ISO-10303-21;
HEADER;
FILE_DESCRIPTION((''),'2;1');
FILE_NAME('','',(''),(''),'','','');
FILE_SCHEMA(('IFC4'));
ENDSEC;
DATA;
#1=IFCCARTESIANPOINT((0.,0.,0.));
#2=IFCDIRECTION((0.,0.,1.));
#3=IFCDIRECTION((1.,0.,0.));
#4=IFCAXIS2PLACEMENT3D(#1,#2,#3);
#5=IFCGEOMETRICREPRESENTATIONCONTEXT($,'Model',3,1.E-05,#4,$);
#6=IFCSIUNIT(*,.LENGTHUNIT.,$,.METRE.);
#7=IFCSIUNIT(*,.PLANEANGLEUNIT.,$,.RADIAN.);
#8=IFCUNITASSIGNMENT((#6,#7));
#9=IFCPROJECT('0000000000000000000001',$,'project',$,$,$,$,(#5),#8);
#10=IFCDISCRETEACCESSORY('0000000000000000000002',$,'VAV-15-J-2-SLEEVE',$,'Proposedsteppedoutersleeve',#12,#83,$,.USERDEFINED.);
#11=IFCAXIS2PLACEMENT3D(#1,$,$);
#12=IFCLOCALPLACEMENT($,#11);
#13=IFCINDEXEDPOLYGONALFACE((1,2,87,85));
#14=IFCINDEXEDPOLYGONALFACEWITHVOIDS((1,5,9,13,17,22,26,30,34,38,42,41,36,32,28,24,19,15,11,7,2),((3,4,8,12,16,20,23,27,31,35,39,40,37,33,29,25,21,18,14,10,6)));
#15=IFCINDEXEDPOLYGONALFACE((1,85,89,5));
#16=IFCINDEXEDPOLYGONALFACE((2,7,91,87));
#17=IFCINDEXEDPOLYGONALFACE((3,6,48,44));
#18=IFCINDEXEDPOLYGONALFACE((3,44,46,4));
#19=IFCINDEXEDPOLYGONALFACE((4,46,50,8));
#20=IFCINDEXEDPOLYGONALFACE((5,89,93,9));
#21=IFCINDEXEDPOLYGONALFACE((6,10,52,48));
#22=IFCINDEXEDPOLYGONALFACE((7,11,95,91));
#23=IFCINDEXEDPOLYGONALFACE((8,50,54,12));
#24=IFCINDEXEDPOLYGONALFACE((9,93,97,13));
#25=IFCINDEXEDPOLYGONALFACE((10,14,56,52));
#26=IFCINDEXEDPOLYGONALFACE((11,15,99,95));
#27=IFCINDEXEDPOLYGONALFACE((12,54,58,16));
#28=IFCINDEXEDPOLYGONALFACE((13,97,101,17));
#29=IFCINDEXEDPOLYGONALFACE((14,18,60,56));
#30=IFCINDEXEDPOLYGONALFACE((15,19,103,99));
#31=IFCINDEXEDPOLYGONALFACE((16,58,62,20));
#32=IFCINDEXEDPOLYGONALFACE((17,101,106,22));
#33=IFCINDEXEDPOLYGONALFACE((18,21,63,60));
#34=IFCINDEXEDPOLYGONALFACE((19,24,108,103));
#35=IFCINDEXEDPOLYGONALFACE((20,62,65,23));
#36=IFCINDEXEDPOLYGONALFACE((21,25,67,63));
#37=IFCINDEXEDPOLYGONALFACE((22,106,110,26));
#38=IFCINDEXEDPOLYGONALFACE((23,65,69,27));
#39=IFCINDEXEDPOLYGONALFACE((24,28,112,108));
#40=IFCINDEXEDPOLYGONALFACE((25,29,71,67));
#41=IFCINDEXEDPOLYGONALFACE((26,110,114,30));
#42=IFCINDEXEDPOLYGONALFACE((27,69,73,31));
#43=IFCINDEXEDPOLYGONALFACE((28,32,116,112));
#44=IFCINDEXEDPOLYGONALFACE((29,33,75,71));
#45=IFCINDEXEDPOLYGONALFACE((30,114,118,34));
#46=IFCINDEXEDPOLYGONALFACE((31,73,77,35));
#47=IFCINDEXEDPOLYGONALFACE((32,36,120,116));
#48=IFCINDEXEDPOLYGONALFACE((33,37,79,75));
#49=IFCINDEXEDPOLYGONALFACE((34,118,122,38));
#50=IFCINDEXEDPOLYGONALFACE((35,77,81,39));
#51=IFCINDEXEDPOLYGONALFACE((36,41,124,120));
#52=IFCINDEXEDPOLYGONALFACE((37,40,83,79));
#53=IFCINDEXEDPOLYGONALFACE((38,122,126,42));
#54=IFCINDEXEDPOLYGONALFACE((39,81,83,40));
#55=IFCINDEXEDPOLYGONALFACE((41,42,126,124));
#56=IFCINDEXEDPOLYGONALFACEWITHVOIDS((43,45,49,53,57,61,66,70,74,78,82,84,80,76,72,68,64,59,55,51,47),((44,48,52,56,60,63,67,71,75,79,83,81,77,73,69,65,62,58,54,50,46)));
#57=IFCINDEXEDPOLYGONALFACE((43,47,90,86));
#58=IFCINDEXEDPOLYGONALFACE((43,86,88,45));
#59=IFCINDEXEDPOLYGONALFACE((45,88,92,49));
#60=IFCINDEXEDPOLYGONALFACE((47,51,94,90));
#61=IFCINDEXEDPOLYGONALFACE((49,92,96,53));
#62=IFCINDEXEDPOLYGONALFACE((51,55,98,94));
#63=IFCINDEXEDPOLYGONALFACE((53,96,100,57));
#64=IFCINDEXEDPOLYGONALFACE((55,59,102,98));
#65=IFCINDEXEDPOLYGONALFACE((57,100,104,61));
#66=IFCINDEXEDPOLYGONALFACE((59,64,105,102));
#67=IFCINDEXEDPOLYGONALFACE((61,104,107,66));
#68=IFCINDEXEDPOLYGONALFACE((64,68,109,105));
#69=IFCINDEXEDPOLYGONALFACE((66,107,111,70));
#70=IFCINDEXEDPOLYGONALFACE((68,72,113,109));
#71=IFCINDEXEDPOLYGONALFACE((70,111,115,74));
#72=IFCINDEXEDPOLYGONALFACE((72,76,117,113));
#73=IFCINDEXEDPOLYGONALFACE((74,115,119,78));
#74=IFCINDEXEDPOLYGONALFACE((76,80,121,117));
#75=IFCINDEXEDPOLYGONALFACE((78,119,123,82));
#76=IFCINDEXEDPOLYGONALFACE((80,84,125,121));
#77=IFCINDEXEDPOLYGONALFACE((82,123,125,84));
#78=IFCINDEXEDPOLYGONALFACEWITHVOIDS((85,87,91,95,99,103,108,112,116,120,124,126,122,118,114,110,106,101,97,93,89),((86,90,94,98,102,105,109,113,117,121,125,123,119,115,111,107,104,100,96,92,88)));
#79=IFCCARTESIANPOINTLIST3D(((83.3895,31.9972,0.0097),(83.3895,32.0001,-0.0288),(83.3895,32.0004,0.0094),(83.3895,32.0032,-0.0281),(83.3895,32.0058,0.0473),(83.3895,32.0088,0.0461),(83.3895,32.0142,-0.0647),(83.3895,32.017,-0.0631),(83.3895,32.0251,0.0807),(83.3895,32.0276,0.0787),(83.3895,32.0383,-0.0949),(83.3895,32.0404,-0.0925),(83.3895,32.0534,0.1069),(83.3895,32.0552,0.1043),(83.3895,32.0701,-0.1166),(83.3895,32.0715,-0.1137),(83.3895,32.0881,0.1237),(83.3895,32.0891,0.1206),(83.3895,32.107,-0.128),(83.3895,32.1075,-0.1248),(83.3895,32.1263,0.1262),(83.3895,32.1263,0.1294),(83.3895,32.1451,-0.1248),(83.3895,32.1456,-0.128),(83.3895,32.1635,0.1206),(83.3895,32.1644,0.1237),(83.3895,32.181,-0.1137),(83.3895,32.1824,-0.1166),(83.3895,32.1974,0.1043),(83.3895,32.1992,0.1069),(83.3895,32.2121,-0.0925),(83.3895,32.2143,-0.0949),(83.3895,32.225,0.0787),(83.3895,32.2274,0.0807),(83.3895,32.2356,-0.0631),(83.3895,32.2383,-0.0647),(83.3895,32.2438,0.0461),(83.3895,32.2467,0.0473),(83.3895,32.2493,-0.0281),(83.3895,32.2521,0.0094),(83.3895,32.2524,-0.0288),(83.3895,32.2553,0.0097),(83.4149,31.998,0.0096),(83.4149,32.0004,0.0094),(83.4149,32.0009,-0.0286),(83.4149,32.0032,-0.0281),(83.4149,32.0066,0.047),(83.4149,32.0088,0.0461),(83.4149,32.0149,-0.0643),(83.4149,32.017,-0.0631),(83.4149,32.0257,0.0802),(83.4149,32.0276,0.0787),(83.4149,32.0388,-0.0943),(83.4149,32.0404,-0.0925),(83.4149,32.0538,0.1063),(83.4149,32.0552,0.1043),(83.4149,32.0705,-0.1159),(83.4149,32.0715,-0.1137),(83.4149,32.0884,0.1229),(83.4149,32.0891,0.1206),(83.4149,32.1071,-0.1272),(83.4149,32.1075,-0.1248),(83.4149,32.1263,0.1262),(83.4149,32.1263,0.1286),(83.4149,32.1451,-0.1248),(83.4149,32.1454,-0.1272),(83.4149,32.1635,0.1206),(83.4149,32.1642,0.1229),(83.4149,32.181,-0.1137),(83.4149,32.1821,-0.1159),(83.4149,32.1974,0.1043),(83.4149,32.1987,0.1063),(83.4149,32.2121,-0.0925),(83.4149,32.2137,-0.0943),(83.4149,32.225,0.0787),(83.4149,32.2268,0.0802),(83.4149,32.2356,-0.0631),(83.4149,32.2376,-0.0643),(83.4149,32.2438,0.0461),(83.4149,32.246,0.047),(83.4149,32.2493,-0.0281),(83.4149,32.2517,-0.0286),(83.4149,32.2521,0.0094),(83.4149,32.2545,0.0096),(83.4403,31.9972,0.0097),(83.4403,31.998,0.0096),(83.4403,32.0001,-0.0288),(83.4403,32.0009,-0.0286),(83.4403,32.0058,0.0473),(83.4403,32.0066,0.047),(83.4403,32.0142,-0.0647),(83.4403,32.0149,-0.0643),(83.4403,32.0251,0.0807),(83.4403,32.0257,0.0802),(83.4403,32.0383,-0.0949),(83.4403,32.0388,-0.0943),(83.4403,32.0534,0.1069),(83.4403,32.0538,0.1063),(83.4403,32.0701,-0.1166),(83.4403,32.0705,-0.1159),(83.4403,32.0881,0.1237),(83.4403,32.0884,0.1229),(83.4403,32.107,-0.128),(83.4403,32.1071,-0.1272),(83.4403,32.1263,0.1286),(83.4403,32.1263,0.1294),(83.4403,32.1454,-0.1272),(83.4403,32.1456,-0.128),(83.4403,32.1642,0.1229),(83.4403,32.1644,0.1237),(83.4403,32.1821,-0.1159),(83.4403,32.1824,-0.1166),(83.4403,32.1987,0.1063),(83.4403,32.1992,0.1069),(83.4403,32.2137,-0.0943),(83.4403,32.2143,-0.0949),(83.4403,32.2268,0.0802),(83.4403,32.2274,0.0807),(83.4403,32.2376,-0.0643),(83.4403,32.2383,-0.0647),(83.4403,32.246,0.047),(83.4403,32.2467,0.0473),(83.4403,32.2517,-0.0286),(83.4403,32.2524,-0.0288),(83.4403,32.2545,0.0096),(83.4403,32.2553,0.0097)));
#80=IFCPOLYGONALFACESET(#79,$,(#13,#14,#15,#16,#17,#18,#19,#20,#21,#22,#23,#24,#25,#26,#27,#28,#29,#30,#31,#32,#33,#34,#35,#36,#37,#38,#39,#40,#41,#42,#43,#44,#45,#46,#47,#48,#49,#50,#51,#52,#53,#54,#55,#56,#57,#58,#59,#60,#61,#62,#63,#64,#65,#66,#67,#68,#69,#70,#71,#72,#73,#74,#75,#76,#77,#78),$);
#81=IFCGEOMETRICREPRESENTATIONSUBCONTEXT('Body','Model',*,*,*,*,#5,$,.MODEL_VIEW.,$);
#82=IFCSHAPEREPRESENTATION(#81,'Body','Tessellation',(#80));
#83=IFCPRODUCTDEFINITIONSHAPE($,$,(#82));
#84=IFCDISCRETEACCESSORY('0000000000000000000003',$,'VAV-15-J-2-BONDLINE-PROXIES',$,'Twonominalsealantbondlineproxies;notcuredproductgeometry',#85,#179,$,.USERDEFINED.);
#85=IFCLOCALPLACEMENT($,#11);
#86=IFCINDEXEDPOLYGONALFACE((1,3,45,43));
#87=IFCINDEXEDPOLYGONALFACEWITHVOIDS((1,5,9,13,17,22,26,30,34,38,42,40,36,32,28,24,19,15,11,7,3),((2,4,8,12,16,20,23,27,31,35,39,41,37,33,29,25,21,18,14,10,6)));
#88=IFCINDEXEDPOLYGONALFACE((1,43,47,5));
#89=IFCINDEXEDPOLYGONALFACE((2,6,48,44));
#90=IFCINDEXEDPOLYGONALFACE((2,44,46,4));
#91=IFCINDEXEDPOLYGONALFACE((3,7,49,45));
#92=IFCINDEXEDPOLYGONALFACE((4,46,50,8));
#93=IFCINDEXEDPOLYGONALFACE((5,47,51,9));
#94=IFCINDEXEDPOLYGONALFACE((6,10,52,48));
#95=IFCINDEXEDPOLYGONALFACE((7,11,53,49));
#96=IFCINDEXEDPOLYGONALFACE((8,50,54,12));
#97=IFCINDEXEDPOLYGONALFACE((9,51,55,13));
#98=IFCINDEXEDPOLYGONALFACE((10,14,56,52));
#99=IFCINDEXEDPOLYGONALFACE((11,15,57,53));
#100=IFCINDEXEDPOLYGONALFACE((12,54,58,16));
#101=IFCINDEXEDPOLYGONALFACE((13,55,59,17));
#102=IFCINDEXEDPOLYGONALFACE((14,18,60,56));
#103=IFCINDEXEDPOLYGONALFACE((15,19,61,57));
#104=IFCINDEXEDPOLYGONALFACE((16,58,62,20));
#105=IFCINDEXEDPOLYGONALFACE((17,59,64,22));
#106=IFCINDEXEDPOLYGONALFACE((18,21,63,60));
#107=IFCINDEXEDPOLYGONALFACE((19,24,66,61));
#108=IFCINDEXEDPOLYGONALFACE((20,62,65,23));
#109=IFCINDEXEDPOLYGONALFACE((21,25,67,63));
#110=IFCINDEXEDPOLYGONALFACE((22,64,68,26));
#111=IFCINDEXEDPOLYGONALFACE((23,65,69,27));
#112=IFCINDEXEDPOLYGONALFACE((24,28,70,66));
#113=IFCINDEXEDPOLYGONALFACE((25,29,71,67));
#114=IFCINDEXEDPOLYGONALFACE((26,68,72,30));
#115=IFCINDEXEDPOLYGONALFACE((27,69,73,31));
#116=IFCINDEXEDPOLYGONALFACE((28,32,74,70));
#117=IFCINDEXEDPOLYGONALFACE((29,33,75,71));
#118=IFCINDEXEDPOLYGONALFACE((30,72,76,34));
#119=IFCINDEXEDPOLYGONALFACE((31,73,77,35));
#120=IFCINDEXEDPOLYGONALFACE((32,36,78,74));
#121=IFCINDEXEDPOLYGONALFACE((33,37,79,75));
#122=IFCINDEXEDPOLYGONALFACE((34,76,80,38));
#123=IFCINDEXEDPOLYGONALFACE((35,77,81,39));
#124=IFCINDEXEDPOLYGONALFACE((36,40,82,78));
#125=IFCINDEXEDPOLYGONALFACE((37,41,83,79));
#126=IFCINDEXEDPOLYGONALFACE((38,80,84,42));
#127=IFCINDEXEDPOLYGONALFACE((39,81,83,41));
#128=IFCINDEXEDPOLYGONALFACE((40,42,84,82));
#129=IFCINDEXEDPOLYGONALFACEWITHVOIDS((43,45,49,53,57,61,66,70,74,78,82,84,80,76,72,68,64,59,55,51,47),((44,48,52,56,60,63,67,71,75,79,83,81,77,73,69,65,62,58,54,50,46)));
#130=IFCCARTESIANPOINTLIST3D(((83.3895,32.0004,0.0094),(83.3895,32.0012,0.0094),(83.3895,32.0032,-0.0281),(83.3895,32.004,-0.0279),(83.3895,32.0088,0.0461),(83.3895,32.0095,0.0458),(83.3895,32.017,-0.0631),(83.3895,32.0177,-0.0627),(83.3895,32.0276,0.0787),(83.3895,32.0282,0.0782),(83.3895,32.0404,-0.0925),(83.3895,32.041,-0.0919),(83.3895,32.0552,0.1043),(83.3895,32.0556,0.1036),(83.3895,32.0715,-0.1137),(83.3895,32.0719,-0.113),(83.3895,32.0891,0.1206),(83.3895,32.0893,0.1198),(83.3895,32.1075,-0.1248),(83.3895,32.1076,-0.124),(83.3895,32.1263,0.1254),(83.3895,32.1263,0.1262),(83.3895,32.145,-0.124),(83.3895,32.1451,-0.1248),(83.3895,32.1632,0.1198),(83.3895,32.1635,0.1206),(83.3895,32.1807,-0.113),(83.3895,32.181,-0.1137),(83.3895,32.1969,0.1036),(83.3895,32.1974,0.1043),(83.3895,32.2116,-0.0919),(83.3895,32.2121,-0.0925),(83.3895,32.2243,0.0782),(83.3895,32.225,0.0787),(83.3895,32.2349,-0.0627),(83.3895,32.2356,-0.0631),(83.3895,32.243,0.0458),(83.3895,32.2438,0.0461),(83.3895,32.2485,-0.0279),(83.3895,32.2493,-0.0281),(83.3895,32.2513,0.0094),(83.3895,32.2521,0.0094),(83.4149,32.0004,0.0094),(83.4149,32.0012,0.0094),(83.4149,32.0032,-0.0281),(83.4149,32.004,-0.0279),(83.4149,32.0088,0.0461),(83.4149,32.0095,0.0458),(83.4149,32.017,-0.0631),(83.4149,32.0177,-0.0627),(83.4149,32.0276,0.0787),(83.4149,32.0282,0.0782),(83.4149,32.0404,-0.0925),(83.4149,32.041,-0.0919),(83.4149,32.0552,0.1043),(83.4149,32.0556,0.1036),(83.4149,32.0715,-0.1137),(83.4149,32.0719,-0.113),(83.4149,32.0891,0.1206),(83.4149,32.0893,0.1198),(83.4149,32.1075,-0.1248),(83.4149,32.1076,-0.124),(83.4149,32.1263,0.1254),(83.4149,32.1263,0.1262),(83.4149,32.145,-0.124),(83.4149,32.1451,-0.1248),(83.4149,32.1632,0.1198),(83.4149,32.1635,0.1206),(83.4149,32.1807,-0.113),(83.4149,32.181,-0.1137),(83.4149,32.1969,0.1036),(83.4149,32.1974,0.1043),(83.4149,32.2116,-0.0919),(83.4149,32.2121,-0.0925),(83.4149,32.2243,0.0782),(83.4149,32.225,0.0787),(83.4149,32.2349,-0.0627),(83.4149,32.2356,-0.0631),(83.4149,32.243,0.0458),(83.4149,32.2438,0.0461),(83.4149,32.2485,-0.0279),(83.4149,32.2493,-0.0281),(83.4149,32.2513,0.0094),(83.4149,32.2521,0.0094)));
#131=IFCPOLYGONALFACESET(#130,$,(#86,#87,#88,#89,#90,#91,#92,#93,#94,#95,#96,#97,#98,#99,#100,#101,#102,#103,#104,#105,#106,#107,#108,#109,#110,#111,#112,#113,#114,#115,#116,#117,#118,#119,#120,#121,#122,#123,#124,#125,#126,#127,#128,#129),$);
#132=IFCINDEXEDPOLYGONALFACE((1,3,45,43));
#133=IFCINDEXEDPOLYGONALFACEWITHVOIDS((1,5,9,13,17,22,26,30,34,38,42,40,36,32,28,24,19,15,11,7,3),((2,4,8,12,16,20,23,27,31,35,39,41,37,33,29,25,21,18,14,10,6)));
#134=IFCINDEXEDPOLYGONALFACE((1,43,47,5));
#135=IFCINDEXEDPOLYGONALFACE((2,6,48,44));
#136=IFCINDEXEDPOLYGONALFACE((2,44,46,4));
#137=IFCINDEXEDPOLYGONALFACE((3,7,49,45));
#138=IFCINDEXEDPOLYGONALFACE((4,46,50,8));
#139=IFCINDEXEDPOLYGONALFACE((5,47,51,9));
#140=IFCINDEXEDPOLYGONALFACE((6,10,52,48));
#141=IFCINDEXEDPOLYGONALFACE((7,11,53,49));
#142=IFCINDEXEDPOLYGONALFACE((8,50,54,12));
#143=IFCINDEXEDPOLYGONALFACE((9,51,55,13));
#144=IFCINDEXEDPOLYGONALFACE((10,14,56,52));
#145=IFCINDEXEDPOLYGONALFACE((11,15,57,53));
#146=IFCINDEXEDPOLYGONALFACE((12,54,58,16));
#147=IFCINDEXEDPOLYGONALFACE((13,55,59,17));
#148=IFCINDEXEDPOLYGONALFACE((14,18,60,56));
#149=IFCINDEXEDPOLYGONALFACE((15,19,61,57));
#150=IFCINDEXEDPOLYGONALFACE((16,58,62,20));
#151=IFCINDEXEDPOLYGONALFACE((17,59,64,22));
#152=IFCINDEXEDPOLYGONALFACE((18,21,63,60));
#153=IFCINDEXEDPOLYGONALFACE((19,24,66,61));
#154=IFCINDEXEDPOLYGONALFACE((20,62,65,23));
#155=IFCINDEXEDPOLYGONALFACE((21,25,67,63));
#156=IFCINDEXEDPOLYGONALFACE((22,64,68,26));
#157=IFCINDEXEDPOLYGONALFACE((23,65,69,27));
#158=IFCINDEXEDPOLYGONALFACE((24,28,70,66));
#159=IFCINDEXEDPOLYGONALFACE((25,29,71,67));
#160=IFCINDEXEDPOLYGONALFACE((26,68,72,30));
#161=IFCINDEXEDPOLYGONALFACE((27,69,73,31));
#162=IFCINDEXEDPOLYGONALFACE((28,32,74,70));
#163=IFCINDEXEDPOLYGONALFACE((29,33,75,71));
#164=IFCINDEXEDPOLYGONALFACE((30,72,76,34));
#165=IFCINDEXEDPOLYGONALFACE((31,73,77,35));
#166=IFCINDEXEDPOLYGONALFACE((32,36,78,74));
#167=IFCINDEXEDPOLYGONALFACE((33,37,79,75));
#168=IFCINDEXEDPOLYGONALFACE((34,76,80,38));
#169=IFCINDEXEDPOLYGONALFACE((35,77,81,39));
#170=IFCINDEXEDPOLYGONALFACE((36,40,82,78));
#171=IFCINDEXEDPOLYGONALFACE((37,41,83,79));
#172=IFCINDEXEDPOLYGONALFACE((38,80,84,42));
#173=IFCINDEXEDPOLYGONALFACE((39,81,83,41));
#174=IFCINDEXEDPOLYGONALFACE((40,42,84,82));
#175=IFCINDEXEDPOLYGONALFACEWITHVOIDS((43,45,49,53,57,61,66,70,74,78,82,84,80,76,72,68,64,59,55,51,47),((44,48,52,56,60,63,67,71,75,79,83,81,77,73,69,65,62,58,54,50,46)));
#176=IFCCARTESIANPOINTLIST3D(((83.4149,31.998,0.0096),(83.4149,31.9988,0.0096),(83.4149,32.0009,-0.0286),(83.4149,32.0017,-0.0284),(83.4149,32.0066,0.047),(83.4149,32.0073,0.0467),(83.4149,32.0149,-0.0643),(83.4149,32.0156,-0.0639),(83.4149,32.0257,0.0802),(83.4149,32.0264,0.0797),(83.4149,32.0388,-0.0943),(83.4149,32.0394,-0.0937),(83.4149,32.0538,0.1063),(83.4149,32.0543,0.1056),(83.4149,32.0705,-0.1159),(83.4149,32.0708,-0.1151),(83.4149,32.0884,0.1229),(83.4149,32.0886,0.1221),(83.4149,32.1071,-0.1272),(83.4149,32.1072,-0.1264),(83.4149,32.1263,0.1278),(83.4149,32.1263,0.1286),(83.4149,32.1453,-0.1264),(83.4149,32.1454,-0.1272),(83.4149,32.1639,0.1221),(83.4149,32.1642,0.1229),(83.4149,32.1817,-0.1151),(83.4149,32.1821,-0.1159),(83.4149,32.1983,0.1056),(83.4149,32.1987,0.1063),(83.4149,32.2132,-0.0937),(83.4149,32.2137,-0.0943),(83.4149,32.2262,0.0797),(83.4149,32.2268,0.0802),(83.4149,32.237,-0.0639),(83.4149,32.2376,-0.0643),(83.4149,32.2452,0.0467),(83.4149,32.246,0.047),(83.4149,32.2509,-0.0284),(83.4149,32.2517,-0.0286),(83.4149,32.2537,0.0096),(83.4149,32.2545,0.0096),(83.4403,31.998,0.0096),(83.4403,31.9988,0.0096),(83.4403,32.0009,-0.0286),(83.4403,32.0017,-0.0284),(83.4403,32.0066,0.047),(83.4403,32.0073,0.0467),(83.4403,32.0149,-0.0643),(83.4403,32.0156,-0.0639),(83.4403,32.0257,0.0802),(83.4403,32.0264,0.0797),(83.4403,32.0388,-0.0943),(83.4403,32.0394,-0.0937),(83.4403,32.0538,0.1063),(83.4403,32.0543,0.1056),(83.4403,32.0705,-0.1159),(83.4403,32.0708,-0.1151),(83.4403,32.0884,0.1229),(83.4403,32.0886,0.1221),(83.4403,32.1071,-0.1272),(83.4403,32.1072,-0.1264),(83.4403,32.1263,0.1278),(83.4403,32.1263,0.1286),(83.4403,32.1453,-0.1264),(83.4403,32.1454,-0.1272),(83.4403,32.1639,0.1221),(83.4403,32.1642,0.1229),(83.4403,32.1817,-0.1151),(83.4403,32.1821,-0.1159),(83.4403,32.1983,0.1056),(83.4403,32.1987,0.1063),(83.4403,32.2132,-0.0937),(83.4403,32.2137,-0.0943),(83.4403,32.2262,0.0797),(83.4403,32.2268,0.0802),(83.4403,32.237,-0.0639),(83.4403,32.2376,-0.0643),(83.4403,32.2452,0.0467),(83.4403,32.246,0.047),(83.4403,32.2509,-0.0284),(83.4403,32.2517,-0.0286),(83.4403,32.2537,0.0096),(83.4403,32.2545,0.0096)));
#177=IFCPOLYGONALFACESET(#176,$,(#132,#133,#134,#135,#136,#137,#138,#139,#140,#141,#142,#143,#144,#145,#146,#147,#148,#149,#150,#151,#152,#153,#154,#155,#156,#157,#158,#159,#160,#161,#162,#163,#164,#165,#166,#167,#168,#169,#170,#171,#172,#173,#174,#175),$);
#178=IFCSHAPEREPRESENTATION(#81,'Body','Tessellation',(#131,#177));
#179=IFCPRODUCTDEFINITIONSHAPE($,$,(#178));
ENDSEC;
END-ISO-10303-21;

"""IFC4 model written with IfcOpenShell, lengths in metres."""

from ifc_helpers import new_model, entity, si_unit, frame, origin_with_axes, place, context, subcontext, project, element, save


model = new_model("IFC4")

# Units and contexts
model_context = context("Model", 3, precision=1e-05, world=origin_with_axes())
body_context = subcontext(model_context, "Body", "Model", "MODEL_VIEW")
ifc_project = project(units=[si_unit("LENGTHUNIT", "METRE"), si_unit("PLANEANGLEUNIT", "RADIAN")], contexts=[model_context])

# Discrete accessories
discrete_accessory_1_placement = place(None, frame((83.4149, 32.1263, 0.0), z_axis=(0.0, 1.0, 0.0), x_axis=(0.0, 0.0, 1.0)))
element("IfcDiscreteAccessory", 1, at=discrete_accessory_1_placement, Name="VAV-15-J-2-SLEEVE", ObjectType="Proposedsteppedoutersleeve", PredefinedType="USERDEFINED", context=body_context, shape_type="SweptSolid", body=[
    entity("IfcRevolvedAreaSolid", entity("IfcArbitraryClosedProfileDef", "AREA", None, entity("IfcPolyline", [entity("IfcCartesianPoint", [0.1262, -0.0254]), entity("IfcCartesianPoint", [0.1294, -0.0254]), entity("IfcCartesianPoint", [0.1294, 0.0254]), entity("IfcCartesianPoint", [0.1286, 0.0254]), entity("IfcCartesianPoint", [0.1286, 0.0]), entity("IfcCartesianPoint", [0.1262, 0.0]), entity("IfcCartesianPoint", [0.1262, -0.0254])])), entity("IfcAxis2Placement3D", entity("IfcCartesianPoint", [0.0, 0.0, 0.0])), entity("IfcAxis1Placement", entity("IfcCartesianPoint", [0.0, 0.0, 0.0]), entity("IfcDirection", [0.0, 1.0, 0.0])), 6.283185),
])
discrete_accessory_2_placement = place(None, frame((83.4149, 32.1263, 0.0), z_axis=(0.0, 1.0, 0.0), x_axis=(0.0, 0.0, 1.0)))
element("IfcDiscreteAccessory", 2, at=discrete_accessory_2_placement, Name="VAV-15-J-2-BONDLINE-PROXIES", ObjectType="Twonominalsealantbondlineproxies;notcuredproductgeometry", PredefinedType="USERDEFINED", context=body_context, shape_type="SweptSolid", body=[
    entity("IfcRevolvedAreaSolid", entity("IfcArbitraryClosedProfileDef", "AREA", None, entity("IfcPolyline", [entity("IfcCartesianPoint", [0.1254, -0.0254]), entity("IfcCartesianPoint", [0.1262, -0.0254]), entity("IfcCartesianPoint", [0.1262, 0.0]), entity("IfcCartesianPoint", [0.1254, 0.0]), entity("IfcCartesianPoint", [0.1254, -0.0254])])), entity("IfcAxis2Placement3D", entity("IfcCartesianPoint", [0.0, 0.0, 0.0])), entity("IfcAxis1Placement", entity("IfcCartesianPoint", [0.0, 0.0, 0.0]), entity("IfcDirection", [0.0, 1.0, 0.0])), 6.283185),
    entity("IfcRevolvedAreaSolid", entity("IfcArbitraryClosedProfileDef", "AREA", None, entity("IfcPolyline", [entity("IfcCartesianPoint", [0.1278, 0.0]), entity("IfcCartesianPoint", [0.1286, 0.0]), entity("IfcCartesianPoint", [0.1286, 0.0254]), entity("IfcCartesianPoint", [0.1278, 0.0254]), entity("IfcCartesianPoint", [0.1278, 0.0])])), entity("IfcAxis2Placement3D", entity("IfcCartesianPoint", [0.0, 0.0, 0.0])), entity("IfcAxis1Placement", entity("IfcCartesianPoint", [0.0, 0.0, 0.0]), entity("IfcDirection", [0.0, 1.0, 0.0])), 6.283185),
])

save(model, "model.ifc")
